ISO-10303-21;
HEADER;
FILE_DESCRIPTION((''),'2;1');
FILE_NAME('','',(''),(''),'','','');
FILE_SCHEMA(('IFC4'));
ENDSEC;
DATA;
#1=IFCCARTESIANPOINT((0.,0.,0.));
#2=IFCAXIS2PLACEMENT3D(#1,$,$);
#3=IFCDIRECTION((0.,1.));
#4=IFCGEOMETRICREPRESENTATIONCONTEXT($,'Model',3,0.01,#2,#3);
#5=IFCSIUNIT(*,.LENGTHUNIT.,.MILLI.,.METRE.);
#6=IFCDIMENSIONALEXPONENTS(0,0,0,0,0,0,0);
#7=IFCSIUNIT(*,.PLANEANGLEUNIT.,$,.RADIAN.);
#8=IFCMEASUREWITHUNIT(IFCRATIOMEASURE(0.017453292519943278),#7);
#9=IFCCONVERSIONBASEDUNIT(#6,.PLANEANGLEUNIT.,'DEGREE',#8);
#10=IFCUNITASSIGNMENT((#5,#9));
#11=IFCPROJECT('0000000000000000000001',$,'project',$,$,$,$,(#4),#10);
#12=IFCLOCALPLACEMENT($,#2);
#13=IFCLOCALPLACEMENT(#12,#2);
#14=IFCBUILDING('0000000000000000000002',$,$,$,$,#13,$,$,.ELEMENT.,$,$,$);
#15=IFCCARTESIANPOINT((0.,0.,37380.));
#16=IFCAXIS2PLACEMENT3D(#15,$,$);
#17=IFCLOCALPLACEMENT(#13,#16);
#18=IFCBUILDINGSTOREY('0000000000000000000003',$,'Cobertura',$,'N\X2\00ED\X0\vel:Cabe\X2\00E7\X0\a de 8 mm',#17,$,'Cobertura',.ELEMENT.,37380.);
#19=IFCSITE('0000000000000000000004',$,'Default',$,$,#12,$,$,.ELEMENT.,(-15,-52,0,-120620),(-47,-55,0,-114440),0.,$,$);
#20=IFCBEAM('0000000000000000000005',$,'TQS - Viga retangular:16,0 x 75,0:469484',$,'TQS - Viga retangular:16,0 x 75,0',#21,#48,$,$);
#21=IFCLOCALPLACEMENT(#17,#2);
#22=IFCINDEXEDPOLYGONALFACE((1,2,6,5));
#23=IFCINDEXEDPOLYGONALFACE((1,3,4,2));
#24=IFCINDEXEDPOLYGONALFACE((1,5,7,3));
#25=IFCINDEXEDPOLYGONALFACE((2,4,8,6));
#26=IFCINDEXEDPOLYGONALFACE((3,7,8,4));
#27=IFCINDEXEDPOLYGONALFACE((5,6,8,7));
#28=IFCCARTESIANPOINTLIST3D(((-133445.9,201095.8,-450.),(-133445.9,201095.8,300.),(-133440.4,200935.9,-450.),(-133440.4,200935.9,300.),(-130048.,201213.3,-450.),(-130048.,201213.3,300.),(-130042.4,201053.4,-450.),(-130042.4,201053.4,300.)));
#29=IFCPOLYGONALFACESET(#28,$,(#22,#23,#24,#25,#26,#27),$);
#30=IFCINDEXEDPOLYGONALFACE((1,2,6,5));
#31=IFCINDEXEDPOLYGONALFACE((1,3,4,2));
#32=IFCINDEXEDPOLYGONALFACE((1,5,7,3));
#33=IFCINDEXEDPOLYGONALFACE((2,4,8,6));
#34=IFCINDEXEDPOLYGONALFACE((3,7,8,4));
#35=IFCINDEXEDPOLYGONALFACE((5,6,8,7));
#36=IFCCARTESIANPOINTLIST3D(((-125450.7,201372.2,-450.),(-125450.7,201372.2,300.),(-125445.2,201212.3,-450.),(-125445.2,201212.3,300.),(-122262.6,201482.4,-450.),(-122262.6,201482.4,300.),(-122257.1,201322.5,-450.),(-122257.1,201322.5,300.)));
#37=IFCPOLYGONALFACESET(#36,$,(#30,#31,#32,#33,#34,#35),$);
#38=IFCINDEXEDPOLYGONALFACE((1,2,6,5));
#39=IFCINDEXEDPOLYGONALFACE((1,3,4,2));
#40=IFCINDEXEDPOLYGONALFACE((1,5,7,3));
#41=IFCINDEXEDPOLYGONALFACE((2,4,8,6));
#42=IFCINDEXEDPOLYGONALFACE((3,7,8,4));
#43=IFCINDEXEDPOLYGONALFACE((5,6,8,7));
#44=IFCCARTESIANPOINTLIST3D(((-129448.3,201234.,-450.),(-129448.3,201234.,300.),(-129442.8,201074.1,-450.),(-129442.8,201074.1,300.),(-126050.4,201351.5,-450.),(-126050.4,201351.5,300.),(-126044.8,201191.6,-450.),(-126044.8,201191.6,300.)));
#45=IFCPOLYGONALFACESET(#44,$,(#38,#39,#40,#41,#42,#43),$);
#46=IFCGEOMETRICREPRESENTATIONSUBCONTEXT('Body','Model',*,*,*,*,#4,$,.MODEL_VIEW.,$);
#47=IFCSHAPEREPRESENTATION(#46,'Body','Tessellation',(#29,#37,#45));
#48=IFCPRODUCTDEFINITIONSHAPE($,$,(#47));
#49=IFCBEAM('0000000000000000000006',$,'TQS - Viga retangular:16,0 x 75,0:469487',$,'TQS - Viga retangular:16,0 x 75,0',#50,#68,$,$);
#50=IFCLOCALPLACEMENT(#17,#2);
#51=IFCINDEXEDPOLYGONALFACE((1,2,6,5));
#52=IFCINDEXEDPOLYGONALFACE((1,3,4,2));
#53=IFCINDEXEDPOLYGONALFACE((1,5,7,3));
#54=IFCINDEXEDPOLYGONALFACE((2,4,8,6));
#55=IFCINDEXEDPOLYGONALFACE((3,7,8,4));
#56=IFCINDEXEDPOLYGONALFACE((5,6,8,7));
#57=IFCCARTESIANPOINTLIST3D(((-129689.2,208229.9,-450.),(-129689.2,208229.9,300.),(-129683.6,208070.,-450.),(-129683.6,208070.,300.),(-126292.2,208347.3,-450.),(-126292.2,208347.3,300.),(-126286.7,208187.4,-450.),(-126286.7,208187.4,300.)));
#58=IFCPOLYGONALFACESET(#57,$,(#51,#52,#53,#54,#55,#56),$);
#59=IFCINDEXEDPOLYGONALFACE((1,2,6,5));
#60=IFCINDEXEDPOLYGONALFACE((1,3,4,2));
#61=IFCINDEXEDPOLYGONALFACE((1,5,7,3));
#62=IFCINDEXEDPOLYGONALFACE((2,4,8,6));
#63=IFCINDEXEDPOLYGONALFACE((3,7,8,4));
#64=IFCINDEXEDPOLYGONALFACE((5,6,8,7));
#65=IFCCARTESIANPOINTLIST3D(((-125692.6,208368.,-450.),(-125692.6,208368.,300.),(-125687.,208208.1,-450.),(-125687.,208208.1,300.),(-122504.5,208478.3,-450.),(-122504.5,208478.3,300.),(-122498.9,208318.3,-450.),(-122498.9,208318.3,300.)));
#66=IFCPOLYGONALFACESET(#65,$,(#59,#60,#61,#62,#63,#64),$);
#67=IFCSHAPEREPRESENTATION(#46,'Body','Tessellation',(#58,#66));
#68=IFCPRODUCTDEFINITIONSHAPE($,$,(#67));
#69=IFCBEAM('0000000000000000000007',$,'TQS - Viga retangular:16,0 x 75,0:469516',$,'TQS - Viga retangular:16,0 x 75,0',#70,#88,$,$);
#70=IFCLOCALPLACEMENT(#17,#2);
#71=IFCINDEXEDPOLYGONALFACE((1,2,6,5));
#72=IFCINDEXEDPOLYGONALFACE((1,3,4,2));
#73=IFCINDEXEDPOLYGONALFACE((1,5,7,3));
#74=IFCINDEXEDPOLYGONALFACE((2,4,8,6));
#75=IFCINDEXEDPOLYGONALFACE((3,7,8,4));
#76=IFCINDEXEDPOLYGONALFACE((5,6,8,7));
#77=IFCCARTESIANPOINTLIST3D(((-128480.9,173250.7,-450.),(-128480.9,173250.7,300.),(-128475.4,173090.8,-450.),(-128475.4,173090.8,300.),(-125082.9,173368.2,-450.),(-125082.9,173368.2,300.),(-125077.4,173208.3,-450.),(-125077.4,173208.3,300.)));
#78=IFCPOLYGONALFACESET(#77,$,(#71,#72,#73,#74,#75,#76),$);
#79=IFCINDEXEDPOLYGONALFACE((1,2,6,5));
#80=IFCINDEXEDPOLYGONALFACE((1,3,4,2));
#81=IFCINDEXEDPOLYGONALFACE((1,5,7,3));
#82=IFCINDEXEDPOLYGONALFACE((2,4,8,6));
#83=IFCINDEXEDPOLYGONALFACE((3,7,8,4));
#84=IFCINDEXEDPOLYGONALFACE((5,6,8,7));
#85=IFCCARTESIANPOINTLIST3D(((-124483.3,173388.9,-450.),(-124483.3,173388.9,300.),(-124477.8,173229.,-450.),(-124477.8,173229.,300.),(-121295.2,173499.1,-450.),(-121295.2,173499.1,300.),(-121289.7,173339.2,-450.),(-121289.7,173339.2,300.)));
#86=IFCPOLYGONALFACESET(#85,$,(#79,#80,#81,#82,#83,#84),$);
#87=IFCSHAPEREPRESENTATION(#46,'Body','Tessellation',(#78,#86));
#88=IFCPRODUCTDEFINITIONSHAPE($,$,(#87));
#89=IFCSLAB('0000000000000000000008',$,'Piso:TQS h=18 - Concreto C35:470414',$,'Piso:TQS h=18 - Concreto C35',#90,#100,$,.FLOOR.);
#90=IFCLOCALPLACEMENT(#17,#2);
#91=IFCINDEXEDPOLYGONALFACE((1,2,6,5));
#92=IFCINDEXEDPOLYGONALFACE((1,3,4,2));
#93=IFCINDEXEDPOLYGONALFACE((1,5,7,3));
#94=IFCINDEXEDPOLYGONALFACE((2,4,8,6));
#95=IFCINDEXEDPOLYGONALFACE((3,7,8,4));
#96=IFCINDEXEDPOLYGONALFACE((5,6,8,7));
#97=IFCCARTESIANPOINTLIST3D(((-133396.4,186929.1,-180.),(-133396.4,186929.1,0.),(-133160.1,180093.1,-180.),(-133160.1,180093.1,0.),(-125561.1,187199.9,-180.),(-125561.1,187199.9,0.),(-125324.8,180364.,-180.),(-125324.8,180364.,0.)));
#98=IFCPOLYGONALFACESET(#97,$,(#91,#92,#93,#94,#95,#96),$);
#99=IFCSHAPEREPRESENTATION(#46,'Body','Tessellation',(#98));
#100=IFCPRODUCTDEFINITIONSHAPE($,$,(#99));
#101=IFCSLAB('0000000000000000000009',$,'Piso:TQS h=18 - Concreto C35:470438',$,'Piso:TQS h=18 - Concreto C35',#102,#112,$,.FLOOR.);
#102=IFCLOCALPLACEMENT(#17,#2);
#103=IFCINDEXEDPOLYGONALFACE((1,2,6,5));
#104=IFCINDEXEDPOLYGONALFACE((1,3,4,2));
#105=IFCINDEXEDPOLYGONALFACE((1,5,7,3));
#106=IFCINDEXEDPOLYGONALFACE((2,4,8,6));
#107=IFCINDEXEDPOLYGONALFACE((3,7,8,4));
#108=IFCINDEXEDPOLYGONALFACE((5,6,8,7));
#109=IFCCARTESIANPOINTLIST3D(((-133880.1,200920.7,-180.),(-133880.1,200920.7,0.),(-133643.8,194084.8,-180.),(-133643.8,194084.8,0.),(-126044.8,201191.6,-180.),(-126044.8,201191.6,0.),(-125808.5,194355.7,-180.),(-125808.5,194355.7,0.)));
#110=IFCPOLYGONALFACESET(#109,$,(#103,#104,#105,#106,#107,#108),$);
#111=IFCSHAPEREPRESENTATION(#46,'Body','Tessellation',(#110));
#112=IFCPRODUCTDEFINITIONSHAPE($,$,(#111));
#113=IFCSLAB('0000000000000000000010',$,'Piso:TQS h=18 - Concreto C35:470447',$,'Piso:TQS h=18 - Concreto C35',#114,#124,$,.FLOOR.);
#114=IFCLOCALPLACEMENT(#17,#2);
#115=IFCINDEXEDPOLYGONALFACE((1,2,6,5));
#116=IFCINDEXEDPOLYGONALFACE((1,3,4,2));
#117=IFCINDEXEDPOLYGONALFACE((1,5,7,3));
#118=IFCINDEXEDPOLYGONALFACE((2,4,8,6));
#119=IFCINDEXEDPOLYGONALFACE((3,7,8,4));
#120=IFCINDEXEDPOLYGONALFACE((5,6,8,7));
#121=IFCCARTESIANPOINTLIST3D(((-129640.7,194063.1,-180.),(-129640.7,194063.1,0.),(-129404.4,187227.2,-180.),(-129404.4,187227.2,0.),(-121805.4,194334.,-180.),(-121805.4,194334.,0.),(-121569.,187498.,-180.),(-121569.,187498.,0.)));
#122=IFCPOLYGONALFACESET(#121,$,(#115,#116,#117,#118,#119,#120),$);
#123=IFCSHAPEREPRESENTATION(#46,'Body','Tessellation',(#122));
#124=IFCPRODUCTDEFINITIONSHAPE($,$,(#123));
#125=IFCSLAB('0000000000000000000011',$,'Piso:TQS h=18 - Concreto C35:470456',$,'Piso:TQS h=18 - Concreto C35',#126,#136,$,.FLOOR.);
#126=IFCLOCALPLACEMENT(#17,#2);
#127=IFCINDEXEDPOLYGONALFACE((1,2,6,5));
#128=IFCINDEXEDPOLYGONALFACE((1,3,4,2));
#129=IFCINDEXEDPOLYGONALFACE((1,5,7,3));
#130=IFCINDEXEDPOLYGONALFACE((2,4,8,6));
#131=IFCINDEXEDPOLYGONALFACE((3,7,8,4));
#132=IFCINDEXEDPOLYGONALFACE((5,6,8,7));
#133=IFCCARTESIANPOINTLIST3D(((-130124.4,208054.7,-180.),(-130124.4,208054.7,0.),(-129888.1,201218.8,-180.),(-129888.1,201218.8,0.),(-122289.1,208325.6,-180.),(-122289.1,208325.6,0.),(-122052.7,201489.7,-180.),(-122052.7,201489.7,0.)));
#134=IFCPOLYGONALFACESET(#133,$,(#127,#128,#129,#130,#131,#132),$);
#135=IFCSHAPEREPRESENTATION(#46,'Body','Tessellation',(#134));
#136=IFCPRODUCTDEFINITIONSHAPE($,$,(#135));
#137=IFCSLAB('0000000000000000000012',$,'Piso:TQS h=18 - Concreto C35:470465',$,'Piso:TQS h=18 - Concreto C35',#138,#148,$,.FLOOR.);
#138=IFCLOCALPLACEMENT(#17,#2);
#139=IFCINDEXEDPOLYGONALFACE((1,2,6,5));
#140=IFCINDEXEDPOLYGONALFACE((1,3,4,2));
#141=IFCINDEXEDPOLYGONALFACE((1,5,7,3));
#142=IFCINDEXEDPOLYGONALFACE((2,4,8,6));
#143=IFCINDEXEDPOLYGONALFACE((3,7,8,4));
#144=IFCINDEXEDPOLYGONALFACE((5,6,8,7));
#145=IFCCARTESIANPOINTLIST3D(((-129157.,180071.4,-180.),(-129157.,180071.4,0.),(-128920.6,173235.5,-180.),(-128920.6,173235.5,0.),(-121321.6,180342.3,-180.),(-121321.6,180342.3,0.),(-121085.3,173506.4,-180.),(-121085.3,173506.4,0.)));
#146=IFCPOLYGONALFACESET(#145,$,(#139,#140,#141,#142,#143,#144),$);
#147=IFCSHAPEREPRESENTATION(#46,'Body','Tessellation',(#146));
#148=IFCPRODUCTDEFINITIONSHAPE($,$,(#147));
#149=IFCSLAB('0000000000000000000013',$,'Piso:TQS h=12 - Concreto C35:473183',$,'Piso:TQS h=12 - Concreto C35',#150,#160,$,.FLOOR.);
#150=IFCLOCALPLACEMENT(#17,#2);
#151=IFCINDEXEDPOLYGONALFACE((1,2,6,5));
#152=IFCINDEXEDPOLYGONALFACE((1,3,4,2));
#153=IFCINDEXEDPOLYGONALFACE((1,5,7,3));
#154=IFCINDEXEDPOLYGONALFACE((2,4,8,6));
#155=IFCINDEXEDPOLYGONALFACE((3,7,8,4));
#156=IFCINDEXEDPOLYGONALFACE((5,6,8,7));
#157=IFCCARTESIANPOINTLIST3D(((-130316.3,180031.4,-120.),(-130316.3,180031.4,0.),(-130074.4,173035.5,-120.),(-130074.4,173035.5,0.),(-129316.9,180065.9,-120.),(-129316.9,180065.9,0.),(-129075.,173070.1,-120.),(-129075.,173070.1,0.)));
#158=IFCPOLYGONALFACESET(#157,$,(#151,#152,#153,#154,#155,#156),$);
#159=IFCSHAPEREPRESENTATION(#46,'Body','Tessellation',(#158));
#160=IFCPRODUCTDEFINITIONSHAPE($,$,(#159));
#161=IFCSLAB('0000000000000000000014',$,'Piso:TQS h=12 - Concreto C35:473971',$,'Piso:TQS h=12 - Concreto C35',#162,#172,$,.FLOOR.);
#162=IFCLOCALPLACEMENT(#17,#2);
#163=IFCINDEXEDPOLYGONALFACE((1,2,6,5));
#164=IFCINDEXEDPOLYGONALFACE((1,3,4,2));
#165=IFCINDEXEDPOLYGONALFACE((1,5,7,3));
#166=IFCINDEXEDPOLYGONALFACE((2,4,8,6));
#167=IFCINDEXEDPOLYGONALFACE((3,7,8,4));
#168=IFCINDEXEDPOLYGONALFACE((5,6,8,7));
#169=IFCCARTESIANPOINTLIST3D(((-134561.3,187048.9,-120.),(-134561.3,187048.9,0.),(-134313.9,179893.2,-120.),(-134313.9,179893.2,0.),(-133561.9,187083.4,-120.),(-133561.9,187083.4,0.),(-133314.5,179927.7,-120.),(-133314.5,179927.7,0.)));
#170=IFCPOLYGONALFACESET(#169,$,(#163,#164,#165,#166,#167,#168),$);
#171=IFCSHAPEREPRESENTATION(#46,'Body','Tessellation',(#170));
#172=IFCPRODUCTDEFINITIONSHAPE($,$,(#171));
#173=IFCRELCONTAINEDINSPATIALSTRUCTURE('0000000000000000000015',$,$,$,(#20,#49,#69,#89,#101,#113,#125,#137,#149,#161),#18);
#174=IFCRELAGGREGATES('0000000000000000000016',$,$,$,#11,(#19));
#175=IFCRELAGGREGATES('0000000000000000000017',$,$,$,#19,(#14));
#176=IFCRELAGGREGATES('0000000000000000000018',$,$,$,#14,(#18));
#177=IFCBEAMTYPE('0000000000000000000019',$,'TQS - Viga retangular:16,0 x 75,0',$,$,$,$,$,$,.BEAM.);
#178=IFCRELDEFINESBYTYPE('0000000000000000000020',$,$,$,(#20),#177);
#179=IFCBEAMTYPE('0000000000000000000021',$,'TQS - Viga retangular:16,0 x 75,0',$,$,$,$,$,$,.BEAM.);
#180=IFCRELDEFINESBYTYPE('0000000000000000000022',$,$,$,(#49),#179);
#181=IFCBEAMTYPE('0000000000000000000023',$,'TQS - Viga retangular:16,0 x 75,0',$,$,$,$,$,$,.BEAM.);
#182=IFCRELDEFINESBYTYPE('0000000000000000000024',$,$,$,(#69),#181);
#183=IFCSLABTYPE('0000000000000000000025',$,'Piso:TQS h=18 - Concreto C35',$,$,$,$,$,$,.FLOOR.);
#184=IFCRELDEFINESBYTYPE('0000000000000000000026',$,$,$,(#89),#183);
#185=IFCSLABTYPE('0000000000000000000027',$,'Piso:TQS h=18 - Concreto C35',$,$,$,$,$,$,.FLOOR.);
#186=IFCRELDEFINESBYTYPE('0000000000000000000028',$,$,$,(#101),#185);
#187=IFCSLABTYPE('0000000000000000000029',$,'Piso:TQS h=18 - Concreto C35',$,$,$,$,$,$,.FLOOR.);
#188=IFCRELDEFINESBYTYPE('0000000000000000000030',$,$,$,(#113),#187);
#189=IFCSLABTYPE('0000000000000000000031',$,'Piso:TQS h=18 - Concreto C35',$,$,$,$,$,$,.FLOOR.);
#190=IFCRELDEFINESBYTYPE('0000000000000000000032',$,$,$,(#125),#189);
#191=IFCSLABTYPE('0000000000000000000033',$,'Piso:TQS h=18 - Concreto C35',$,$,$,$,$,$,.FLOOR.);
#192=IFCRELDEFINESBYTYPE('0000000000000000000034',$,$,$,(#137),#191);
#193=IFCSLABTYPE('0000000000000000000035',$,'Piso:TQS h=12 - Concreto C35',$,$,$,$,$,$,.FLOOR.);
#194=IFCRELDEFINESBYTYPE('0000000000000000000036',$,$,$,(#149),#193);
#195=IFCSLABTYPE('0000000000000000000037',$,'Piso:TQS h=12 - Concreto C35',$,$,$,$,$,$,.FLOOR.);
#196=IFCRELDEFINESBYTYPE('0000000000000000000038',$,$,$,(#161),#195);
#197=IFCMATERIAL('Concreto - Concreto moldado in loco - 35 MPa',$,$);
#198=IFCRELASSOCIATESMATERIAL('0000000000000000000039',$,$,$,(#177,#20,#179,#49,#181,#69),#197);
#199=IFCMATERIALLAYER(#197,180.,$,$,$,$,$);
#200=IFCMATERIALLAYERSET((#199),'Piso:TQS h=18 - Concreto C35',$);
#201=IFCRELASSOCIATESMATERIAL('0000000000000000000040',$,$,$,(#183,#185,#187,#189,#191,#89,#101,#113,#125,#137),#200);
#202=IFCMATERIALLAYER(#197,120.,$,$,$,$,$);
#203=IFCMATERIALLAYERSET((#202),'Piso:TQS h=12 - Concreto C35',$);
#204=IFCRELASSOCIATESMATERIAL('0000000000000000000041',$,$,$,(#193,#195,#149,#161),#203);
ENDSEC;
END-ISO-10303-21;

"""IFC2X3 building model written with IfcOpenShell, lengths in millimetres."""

from ifc_helpers import new_model, entity, si_unit, converted_unit, direction, frame, frame_2d, origin, place, context, subcontext, project, spatial, rectangle, extrude, source, transform, mapped, material, layer, layer_set, layer_usage, type_object, type_shapes, element, save


model = new_model("IFC2X3")

# Units and contexts
model_context = context("Model", 3, precision=0.01, world=origin(), true_north=direction((0.0, 1.0)))
body_context = subcontext(model_context, "Body", "Model", "MODEL_VIEW")
ifc_project = project(units=[si_unit("LENGTHUNIT", "METRE", prefix="MILLI"), converted_unit("PLANEANGLEUNIT", "DEGREE", entity("IfcRatioMeasure", 0.017453292519943278), si_unit("PLANEANGLEUNIT", "RADIAN"), dimensions=[0, 0, 0, 0, 0, 0, 0])], contexts=[model_context])

# Site, building, storey
site_placement = place(None, origin())
site = spatial("IfcSite", under=ifc_project, at=site_placement, Name="Default", CompositionType="ELEMENT", RefLatitude=(-15, -52, 0, -120620), RefLongitude=(-47, -55, 0, -114440), RefElevation=0.0)
building_placement = place(site_placement, origin())
building = spatial("IfcBuilding", under=site, at=building_placement, CompositionType="ELEMENT")
storey_placement = place(building_placement, frame((0.0, 0.0, 37380.0)))
storey = spatial("IfcBuildingStorey", under=building, at=storey_placement, Name="Cobertura", ObjectType="Nível:Cabeça de 8 mm", LongName="Cobertura", CompositionType="ELEMENT", Elevation=37380.0)

# Beams
ifc_material = material(Name="Concreto - Concreto moldado in loco - 35 MPa")
beam_type_1 = type_object("IfcBeamType", Name="TQS - Viga retangular:16,0 x 75,0", PredefinedType="BEAM", material=ifc_material)
shared_shape_1 = source(origin(), body_context, "Body", "SweptSolid", [
    extrude(rectangle(XDim=750.0, YDim=160.0, at=frame_2d((0.0, 0.0), x_axis=(1.0, 0.0))), frame((-130045.2, 201133.3, 37305.0), z_axis=(-0.999403, -0.034551, 0.0), x_axis=(0.0, 0.0, -1.0)), (0.0, 0.0, 1.0), 3400.0),
    extrude(rectangle(XDim=750.0, YDim=160.0, at=frame_2d((0.0, 0.0), x_axis=(1.0, 0.0))), frame((-122259.9, 201402.5, 37305.0), z_axis=(-0.999403, -0.034551, 0.0), x_axis=(0.0, 0.0, -1.0)), (0.0, 0.0, 1.0), 3190.0),
    extrude(rectangle(XDim=750.0, YDim=160.0, at=frame_2d((0.0, 0.0), x_axis=(1.0, 0.0))), frame((-126047.6, 201271.5, 37305.0), z_axis=(-0.999403, -0.034551, 0.0), x_axis=(0.0, 0.0, -1.0)), (0.0, 0.0, 1.0), 3400.0),
])
type_shapes(beam_type_1, [shared_shape_1])
beam_1_placement = place(storey_placement, frame((0.0, 0.0, -37380.0)))
element("IfcBeam", 1, at=beam_1_placement, inside=storey, type_object=beam_type_1, material=ifc_material, Name="TQS - Viga retangular:16,0 x 75,0:469484", ObjectType="TQS - Viga retangular:16,0 x 75,0", context=body_context, shape_type="MappedRepresentation", body=[
    mapped(shared_shape_1, transform((0.0, 0.0, 0.0), scale=1.0)),
])
beam_type_2 = type_object("IfcBeamType", Name="TQS - Viga retangular:16,0 x 75,0", PredefinedType="BEAM", material=ifc_material)
shared_shape_2 = source(origin(), body_context, "Body", "SweptSolid", [
    extrude(rectangle(XDim=750.0, YDim=160.0, at=frame_2d((0.0, 0.0), x_axis=(1.0, 0.0))), frame((-126289.4, 208267.4, 37305.0), z_axis=(-0.999403, -0.034551, 0.0), x_axis=(0.0, 0.0, -1.0)), (0.0, 0.0, 1.0), 3399.0),
    extrude(rectangle(XDim=750.0, YDim=160.0, at=frame_2d((0.0, 0.0), x_axis=(1.0, 0.0))), frame((-122501.7, 208398.3, 37305.0), z_axis=(-0.999403, -0.034551, 0.0), x_axis=(0.0, 0.0, -1.0)), (0.0, 0.0, 1.0), 3190.0),
])
type_shapes(beam_type_2, [shared_shape_2])
beam_2_placement = place(storey_placement, frame((0.0, 0.0, -37380.0)))
element("IfcBeam", 2, at=beam_2_placement, inside=storey, type_object=beam_type_2, material=ifc_material, Name="TQS - Viga retangular:16,0 x 75,0:469487", ObjectType="TQS - Viga retangular:16,0 x 75,0", context=body_context, shape_type="MappedRepresentation", body=[
    mapped(shared_shape_2, transform((0.0, 0.0, 0.0), scale=1.0)),
])
beam_type_3 = type_object("IfcBeamType", Name="TQS - Viga retangular:16,0 x 75,0", PredefinedType="BEAM", material=ifc_material)
shared_shape_3 = source(origin(), body_context, "Body", "SweptSolid", [
    extrude(rectangle(XDim=750.0, YDim=160.0, at=frame_2d((0.0, 0.0), x_axis=(1.0, 0.0))), frame((-125080.2, 173288.2, 37305.0), z_axis=(-0.999403, -0.034551, 0.0), x_axis=(0.0, 0.0, -1.0)), (0.0, 0.0, 1.0), 3400.0),
    extrude(rectangle(XDim=750.0, YDim=160.0, at=frame_2d((0.0, 0.0), x_axis=(1.0, 0.0))), frame((-121292.4, 173419.2, 37305.0), z_axis=(-0.999403, -0.034551, 0.0), x_axis=(0.0, 0.0, -1.0)), (0.0, 0.0, 1.0), 3190.0),
])
type_shapes(beam_type_3, [shared_shape_3])
beam_3_placement = place(storey_placement, frame((0.0, 0.0, -37380.0)))
element("IfcBeam", 3, at=beam_3_placement, inside=storey, type_object=beam_type_3, material=ifc_material, Name="TQS - Viga retangular:16,0 x 75,0:469516", ObjectType="TQS - Viga retangular:16,0 x 75,0", context=body_context, shape_type="MappedRepresentation", body=[
    mapped(shared_shape_3, transform((0.0, 0.0, 0.0), scale=1.0)),
])

# Slabs
ifc_layer_1 = layer(ifc_material, 180.0)
ifc_layer_set_1 = layer_set([ifc_layer_1], Name="Piso:TQS h=18 - Concreto C35")
ifc_layer_usage_1 = layer_usage(ifc_layer_set_1, "AXIS3", "POSITIVE", 0.0)
slab_type_1 = type_object("IfcSlabType", Name="Piso:TQS h=18 - Concreto C35", PredefinedType="FLOOR", material=ifc_layer_set_1)
slab_1_placement = place(storey_placement, origin())
element("IfcSlab", 4, at=slab_1_placement, inside=storey, type_object=slab_type_1, material=ifc_layer_usage_1, Name="Piso:TQS h=18 - Concreto C35:470414", ObjectType="Piso:TQS h=18 - Concreto C35", PredefinedType="FLOOR", context=body_context, shape_type="SweptSolid", body=[
    extrude(rectangle(XDim=6840.0, YDim=7840.0, at=frame_2d((0.0, 0.0), x_axis=(1.0, 0.0))), frame((-129360.6, 183646.5, 0.0), z_axis=(0.0, 0.0, -1.0), x_axis=(0.034551, -0.999403, 0.0)), (0.0, 0.0, 1.0), 180.0),
])
ifc_layer_usage_2 = layer_usage(ifc_layer_set_1, "AXIS3", "POSITIVE", 0.0)
slab_type_2 = type_object("IfcSlabType", Name="Piso:TQS h=18 - Concreto C35", PredefinedType="FLOOR", material=ifc_layer_set_1)
slab_2_placement = place(storey_placement, origin())
element("IfcSlab", 5, at=slab_2_placement, inside=storey, type_object=slab_type_2, material=ifc_layer_usage_2, Name="Piso:TQS h=18 - Concreto C35:470438", ObjectType="Piso:TQS h=18 - Concreto C35", PredefinedType="FLOOR", context=body_context, shape_type="SweptSolid", body=[
    extrude(rectangle(XDim=6840.0, YDim=7840.0, at=frame_2d((0.0, 0.0), x_axis=(1.0, 0.0))), frame((-129844.3, 197638.2, 0.0), z_axis=(0.0, 0.0, -1.0), x_axis=(0.034551, -0.999403, 0.0)), (0.0, 0.0, 1.0), 180.0),
])
ifc_layer_usage_3 = layer_usage(ifc_layer_set_1, "AXIS3", "POSITIVE", 0.0)
slab_type_3 = type_object("IfcSlabType", Name="Piso:TQS h=18 - Concreto C35", PredefinedType="FLOOR", material=ifc_layer_set_1)
slab_3_placement = place(storey_placement, origin())
element("IfcSlab", 6, at=slab_3_placement, inside=storey, type_object=slab_type_3, material=ifc_layer_usage_3, Name="Piso:TQS h=18 - Concreto C35:470447", ObjectType="Piso:TQS h=18 - Concreto C35", PredefinedType="FLOOR", context=body_context, shape_type="SweptSolid", body=[
    extrude(rectangle(XDim=6840.0, YDim=7840.0, at=frame_2d((0.0, 0.0), x_axis=(1.0, 0.0))), frame((-125604.9, 190780.6, 0.0), z_axis=(0.0, 0.0, -1.0), x_axis=(0.034551, -0.999403, 0.0)), (0.0, 0.0, 1.0), 180.0),
])
ifc_layer_usage_4 = layer_usage(ifc_layer_set_1, "AXIS3", "POSITIVE", 0.0)
slab_type_4 = type_object("IfcSlabType", Name="Piso:TQS h=18 - Concreto C35", PredefinedType="FLOOR", material=ifc_layer_set_1)
slab_4_placement = place(storey_placement, origin())
element("IfcSlab", 7, at=slab_4_placement, inside=storey, type_object=slab_type_4, material=ifc_layer_usage_4, Name="Piso:TQS h=18 - Concreto C35:470456", ObjectType="Piso:TQS h=18 - Concreto C35", PredefinedType="FLOOR", context=body_context, shape_type="SweptSolid", body=[
    extrude(rectangle(XDim=7840.0, YDim=6840.0, at=frame_2d((0.0, 0.0), x_axis=(1.0, 0.0))), frame((-126088.6, 204772.2, 0.0), z_axis=(0.0, 0.0, -1.0), x_axis=(0.999403, 0.034551, 0.0)), (0.0, 0.0, 1.0), 180.0),
])
ifc_layer_usage_5 = layer_usage(ifc_layer_set_1, "AXIS3", "POSITIVE", 0.0)
slab_type_5 = type_object("IfcSlabType", Name="Piso:TQS h=18 - Concreto C35", PredefinedType="FLOOR", material=ifc_layer_set_1)
slab_5_placement = place(storey_placement, origin())
element("IfcSlab", 8, at=slab_5_placement, inside=storey, type_object=slab_type_5, material=ifc_layer_usage_5, Name="Piso:TQS h=18 - Concreto C35:470465", ObjectType="Piso:TQS h=18 - Concreto C35", PredefinedType="FLOOR", context=body_context, shape_type="SweptSolid", body=[
    extrude(rectangle(XDim=7840.0, YDim=6840.0, at=frame_2d((0.0, 0.0), x_axis=(1.0, 0.0))), frame((-125121.1, 176788.9, 0.0), z_axis=(0.0, 0.0, -1.0), x_axis=(0.999403, 0.034551, 0.0)), (0.0, 0.0, 1.0), 180.0),
])
ifc_layer_2 = layer(ifc_material, 120.0)
ifc_layer_set_2 = layer_set([ifc_layer_2], Name="Piso:TQS h=12 - Concreto C35")
ifc_layer_usage_6 = layer_usage(ifc_layer_set_2, "AXIS3", "POSITIVE", 0.0)
slab_type_6 = type_object("IfcSlabType", Name="Piso:TQS h=12 - Concreto C35", PredefinedType="FLOOR", material=ifc_layer_set_2)
slab_6_placement = place(storey_placement, origin())
element("IfcSlab", 9, at=slab_6_placement, inside=storey, type_object=slab_type_6, material=ifc_layer_usage_6, Name="Piso:TQS h=12 - Concreto C35:473183", ObjectType="Piso:TQS h=12 - Concreto C35", PredefinedType="FLOOR", context=body_context, shape_type="SweptSolid", body=[
    extrude(rectangle(XDim=7000.0, YDim=1000.0, at=frame_2d((0.0, 0.0), x_axis=(1.0, 0.0))), frame((-129695.6, 176550.7, 0.0), z_axis=(0.0, 0.0, -1.0), x_axis=(0.034551, -0.999403, 0.0)), (0.0, 0.0, 1.0), 120.0),
])
ifc_layer_usage_7 = layer_usage(ifc_layer_set_2, "AXIS3", "POSITIVE", 0.0)
slab_type_7 = type_object("IfcSlabType", Name="Piso:TQS h=12 - Concreto C35", PredefinedType="FLOOR", material=ifc_layer_set_2)
slab_7_placement = place(storey_placement, origin())
element("IfcSlab", 10, at=slab_7_placement, inside=storey, type_object=slab_type_7, material=ifc_layer_usage_7, Name="Piso:TQS h=12 - Concreto C35:473971", ObjectType="Piso:TQS h=12 - Concreto C35", PredefinedType="FLOOR", context=body_context, shape_type="SweptSolid", body=[
    extrude(rectangle(XDim=7160.0, YDim=1000.0, at=frame_2d((0.0, 0.0), x_axis=(1.0, 0.0))), frame((-133937.9, 183488.3, 0.0), z_axis=(0.0, 0.0, -1.0), x_axis=(0.034551, -0.999403, 0.0)), (0.0, 0.0, 1.0), 120.0),
])

save(model, "model.ifc")
